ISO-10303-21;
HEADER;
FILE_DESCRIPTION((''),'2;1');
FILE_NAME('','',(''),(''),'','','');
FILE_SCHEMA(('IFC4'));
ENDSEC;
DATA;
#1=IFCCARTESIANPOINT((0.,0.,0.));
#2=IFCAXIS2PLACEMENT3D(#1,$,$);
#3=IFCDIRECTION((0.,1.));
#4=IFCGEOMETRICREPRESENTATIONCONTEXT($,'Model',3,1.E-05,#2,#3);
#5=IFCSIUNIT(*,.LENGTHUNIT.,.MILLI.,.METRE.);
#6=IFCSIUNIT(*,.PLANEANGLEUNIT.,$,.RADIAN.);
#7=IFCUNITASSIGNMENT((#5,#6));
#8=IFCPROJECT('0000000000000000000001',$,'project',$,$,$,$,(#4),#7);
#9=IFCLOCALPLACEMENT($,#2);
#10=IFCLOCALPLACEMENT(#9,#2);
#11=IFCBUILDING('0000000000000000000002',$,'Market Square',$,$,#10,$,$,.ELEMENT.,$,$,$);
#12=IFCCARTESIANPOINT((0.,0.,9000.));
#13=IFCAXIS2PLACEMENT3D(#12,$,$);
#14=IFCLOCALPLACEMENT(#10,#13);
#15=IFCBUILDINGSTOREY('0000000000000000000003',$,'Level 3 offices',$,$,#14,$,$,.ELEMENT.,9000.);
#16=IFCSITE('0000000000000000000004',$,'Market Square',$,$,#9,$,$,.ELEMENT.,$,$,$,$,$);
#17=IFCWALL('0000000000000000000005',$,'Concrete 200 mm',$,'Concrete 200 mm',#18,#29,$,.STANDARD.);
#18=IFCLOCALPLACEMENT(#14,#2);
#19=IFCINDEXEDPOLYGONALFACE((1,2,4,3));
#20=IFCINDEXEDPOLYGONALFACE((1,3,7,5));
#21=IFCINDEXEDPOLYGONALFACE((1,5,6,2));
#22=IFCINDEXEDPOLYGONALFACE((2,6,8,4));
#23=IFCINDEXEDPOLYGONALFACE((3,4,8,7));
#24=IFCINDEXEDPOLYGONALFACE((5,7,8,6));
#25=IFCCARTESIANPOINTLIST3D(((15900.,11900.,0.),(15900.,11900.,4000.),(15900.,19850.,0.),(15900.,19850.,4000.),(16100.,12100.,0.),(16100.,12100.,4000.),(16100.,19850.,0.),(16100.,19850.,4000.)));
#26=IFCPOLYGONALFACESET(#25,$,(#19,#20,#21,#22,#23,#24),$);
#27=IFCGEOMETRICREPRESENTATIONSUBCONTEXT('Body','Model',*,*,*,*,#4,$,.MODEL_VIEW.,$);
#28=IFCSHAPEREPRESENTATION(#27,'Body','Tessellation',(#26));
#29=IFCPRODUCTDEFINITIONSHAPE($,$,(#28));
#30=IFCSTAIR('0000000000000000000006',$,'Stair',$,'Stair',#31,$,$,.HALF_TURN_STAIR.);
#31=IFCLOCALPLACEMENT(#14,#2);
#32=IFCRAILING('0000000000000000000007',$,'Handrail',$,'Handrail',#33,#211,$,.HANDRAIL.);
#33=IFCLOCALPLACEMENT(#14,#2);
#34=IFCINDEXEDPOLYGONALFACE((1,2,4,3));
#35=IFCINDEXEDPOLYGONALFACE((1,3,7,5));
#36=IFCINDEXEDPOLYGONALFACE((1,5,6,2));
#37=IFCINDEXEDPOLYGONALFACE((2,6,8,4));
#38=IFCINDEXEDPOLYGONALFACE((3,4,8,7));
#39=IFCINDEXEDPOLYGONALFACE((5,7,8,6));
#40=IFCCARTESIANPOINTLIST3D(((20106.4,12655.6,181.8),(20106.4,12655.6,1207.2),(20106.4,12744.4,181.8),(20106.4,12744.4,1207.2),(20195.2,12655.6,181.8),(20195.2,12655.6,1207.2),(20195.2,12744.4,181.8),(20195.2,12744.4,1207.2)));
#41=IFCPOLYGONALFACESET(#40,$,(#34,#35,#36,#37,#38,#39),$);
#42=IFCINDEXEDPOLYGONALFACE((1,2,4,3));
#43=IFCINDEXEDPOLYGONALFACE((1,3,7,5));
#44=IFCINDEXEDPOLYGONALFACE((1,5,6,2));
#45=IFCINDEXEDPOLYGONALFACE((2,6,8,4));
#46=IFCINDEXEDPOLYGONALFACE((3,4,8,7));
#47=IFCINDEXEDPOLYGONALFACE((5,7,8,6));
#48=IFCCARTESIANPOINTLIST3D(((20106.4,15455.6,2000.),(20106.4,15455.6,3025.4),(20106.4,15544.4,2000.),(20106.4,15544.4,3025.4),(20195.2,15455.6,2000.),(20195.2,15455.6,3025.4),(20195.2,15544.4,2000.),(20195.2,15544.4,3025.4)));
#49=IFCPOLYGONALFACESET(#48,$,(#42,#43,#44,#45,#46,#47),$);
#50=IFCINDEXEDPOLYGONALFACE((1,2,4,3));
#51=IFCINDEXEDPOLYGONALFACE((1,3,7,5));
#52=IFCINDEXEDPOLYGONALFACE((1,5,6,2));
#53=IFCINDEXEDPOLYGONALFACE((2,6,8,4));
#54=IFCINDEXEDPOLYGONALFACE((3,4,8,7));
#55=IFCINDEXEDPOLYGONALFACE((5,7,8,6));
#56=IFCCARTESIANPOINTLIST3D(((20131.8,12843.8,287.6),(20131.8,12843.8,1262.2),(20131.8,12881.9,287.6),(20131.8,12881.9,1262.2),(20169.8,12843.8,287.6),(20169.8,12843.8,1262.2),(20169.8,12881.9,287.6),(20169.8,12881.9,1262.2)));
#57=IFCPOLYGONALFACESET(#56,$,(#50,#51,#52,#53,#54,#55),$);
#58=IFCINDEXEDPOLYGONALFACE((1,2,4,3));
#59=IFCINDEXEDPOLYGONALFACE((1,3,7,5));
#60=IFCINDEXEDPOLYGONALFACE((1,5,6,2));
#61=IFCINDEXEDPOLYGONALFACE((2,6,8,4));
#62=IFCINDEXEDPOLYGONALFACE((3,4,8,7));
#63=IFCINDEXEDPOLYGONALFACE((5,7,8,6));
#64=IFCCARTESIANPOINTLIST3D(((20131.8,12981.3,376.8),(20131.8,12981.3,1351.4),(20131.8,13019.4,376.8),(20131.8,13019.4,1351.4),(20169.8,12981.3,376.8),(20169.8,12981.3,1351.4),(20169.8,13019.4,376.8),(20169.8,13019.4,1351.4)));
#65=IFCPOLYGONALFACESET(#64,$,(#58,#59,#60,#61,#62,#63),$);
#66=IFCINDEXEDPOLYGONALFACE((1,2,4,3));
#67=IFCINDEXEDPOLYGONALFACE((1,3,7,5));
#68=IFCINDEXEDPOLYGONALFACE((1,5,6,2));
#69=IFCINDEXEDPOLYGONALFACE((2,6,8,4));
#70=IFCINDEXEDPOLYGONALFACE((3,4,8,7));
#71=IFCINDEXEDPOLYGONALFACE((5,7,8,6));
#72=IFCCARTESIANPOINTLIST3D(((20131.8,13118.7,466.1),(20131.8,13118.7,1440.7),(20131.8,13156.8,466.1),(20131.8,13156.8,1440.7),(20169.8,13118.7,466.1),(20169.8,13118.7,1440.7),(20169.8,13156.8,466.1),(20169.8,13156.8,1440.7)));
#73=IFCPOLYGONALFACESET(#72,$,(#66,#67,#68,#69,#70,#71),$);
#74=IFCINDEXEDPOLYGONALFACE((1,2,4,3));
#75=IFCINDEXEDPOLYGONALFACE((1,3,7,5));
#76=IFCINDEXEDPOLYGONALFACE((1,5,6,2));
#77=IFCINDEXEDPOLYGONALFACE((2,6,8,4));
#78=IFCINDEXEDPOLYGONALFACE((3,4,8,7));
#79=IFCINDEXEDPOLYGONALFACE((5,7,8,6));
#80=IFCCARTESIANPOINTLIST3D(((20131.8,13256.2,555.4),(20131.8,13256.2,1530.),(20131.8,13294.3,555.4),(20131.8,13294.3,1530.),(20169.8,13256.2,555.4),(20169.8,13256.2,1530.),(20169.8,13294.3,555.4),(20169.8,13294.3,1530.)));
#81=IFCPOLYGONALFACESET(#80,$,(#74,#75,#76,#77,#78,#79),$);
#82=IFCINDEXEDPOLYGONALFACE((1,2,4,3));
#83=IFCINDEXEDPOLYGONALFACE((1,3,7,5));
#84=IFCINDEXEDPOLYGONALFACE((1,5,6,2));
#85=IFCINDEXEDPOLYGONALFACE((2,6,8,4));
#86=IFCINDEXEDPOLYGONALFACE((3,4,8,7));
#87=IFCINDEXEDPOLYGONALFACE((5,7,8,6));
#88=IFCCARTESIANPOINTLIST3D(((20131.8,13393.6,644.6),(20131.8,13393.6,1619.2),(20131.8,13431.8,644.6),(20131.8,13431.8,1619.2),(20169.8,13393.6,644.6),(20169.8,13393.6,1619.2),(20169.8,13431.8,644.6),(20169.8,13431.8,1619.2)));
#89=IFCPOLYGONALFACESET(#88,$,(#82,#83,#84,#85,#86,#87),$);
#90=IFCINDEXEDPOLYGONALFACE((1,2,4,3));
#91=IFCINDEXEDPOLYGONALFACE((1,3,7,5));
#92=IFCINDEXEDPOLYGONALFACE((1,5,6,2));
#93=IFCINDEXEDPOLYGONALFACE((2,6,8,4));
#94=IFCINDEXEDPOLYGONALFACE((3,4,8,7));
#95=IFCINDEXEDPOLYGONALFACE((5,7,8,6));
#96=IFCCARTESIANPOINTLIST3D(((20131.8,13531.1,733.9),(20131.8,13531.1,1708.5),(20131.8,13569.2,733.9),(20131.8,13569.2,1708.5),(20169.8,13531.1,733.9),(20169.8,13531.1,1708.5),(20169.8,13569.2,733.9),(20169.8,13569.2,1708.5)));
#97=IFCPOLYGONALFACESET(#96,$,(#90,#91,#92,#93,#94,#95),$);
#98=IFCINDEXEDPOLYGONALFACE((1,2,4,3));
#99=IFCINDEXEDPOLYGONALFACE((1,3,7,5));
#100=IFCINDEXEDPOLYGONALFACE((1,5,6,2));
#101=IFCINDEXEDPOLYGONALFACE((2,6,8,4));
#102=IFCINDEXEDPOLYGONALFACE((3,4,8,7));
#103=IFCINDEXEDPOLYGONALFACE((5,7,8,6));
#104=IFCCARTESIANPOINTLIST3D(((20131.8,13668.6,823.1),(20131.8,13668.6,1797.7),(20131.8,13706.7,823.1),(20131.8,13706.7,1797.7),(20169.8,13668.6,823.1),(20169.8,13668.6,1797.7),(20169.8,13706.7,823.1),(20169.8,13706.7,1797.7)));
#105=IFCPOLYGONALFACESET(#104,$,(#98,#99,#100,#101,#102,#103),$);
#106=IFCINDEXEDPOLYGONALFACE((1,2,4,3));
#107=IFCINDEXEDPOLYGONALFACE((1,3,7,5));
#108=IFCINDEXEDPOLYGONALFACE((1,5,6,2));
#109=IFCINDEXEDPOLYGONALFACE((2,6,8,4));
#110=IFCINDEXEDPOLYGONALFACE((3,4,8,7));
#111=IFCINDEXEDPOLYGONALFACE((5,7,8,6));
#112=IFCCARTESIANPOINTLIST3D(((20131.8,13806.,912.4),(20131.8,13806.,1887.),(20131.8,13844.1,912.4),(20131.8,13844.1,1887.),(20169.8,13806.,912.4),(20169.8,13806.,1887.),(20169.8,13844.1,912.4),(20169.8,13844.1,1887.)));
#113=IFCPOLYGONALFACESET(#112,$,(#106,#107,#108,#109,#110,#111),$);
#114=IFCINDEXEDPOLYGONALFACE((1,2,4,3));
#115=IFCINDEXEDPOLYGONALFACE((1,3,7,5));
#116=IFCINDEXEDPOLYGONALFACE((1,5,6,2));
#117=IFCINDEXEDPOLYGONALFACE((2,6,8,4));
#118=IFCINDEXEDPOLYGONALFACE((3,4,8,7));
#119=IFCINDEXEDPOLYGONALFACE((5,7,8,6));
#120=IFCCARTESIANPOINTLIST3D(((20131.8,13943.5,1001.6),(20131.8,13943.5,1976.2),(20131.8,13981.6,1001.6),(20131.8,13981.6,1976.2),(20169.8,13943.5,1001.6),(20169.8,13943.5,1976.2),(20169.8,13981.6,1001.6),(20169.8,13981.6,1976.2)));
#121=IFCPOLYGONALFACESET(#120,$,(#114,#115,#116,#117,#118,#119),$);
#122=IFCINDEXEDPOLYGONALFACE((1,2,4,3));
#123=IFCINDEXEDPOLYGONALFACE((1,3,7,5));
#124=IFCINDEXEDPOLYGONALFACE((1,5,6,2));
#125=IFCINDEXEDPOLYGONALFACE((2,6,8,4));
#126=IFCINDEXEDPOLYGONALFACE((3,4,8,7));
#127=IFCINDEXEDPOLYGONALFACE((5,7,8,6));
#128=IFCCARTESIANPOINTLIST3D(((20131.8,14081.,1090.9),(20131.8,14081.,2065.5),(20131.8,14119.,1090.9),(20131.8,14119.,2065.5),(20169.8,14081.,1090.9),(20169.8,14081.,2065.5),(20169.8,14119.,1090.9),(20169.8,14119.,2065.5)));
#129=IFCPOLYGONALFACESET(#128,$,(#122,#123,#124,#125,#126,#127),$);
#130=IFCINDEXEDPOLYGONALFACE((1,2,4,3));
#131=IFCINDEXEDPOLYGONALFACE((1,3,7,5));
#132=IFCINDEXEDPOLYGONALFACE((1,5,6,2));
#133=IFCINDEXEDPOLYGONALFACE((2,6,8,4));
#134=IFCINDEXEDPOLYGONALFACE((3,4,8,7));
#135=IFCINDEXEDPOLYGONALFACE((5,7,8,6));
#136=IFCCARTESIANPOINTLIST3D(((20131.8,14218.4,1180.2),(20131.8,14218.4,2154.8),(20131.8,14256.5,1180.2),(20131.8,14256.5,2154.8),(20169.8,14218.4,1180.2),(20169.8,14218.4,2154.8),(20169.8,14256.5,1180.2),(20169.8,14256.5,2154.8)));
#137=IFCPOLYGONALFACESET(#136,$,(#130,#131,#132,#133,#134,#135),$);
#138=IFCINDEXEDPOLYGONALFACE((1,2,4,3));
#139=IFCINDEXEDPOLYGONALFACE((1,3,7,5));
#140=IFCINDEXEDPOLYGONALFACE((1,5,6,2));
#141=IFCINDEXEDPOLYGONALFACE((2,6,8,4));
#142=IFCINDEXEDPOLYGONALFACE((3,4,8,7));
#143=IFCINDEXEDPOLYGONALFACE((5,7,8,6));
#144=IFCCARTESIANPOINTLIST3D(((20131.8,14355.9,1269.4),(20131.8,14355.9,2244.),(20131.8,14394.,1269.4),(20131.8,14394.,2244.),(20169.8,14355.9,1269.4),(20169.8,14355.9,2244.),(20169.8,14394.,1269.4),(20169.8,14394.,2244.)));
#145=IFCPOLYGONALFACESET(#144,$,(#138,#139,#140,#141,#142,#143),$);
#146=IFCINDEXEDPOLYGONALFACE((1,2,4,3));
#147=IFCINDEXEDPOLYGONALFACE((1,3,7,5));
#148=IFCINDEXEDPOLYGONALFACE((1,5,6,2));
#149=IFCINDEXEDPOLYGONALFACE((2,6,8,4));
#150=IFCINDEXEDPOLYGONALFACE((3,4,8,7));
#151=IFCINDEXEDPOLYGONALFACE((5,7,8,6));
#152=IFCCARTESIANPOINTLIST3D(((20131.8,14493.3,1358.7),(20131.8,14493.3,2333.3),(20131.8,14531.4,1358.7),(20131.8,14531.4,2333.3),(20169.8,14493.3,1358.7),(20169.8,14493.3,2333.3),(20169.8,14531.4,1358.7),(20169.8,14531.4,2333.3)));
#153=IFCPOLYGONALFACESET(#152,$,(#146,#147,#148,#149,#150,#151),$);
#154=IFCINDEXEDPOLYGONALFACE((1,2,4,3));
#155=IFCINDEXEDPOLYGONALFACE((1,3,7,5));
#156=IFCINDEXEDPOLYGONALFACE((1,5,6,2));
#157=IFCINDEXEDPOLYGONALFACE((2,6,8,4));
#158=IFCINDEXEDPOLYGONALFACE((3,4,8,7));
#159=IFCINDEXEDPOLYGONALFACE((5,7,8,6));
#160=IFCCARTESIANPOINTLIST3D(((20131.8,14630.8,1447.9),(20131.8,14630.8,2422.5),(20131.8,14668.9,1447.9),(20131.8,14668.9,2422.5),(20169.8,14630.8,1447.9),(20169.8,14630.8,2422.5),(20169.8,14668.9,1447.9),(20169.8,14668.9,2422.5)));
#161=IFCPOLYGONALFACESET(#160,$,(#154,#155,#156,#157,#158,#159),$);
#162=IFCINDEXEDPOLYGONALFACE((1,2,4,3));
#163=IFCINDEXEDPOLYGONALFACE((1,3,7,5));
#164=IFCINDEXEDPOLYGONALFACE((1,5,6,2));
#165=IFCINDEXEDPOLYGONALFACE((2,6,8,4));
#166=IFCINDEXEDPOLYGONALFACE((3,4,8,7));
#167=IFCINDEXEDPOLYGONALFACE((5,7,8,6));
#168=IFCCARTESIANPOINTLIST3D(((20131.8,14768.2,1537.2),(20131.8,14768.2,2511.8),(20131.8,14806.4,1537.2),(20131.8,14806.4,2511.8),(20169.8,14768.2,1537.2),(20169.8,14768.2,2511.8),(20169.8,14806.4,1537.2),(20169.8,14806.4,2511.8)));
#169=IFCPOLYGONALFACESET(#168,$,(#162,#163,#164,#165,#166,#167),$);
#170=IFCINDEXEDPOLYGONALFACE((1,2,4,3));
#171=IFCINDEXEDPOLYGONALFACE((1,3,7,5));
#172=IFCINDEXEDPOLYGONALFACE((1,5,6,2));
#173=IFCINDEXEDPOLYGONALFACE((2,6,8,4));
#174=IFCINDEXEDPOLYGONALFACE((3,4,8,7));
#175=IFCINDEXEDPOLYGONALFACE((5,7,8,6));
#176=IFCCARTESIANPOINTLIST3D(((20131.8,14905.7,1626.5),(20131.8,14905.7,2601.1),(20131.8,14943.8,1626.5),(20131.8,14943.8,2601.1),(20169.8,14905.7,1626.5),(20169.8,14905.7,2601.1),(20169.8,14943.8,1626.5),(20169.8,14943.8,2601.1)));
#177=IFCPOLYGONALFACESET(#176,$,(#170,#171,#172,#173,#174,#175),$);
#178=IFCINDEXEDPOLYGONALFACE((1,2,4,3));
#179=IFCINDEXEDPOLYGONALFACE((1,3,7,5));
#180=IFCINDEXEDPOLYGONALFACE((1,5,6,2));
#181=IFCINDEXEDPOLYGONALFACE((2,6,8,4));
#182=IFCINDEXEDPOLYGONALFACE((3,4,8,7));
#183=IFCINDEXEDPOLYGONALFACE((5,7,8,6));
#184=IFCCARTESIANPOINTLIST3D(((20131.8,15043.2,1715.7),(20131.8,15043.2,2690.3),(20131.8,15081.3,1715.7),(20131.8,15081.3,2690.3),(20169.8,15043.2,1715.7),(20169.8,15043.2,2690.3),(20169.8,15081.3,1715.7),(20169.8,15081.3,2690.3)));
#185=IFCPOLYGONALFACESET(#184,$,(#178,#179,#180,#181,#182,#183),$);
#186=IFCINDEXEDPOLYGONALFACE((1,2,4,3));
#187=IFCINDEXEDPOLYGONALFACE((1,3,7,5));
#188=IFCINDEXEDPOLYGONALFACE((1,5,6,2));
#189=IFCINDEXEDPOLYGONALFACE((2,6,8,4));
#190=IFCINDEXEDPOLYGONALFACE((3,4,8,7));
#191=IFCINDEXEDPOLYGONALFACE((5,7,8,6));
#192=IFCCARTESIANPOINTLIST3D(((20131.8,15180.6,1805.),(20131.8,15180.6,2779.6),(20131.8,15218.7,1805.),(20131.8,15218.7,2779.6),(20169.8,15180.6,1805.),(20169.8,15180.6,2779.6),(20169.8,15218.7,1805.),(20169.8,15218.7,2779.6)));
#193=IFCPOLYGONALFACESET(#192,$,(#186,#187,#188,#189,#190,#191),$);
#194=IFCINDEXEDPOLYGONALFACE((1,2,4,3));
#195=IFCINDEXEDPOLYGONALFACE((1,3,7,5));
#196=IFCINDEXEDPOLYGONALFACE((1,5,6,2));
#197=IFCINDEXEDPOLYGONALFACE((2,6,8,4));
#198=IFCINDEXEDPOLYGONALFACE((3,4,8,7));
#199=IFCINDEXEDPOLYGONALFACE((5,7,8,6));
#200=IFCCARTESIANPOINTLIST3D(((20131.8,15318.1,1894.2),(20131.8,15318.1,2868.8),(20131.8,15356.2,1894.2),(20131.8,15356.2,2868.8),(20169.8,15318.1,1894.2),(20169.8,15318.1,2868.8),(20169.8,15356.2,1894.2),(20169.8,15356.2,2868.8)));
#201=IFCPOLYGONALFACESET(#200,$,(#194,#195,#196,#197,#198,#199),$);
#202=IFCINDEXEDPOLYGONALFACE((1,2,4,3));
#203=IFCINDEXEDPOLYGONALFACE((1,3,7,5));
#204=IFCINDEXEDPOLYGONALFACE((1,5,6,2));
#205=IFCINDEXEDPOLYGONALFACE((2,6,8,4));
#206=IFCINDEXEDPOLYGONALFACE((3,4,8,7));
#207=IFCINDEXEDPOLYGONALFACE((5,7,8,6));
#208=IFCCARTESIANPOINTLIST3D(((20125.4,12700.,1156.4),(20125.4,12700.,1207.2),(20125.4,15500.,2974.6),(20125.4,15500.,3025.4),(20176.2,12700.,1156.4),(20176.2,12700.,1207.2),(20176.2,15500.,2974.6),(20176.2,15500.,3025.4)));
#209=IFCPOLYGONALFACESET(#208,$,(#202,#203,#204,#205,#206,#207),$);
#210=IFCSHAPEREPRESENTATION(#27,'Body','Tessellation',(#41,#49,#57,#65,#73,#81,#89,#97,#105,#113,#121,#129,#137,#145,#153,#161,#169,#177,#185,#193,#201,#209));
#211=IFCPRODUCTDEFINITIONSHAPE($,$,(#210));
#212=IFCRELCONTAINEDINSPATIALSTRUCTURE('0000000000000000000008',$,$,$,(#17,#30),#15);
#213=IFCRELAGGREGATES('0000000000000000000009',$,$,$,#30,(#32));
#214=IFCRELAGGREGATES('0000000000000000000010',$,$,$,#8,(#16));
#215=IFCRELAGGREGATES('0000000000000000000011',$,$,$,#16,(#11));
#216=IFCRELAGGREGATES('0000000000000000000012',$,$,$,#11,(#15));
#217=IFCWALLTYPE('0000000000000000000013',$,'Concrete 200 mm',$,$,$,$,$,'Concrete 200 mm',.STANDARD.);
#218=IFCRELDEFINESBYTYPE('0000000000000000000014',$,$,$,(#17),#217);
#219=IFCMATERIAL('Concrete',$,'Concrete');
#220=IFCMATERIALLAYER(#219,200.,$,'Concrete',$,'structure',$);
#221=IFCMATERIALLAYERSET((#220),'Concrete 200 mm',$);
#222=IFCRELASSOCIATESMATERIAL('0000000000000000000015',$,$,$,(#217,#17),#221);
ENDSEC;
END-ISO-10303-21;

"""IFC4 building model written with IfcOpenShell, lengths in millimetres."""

from ifc_helpers import new_model, si_unit, direction, frame, origin, origin_with_axes, place, context, subcontext, project, spatial, polyline, outline, extrude, material, layer, layer_set, layer_usage, type_object, element, aggregate, save


model = new_model("IFC4")

# Units and contexts
model_context = context("Model", 3, precision=1e-05, world=origin(), true_north=direction((0.0, 1.0)))
body_context = subcontext(model_context, "Body", "Model", "MODEL_VIEW")
ifc_project = project(units=[si_unit("LENGTHUNIT", "METRE", prefix="MILLI"), si_unit("PLANEANGLEUNIT", "RADIAN")], contexts=[model_context])

# Site, building, storey
site_placement = place(None, origin())
site = spatial("IfcSite", under=ifc_project, at=site_placement, Name="Market Square", CompositionType="ELEMENT")
building_placement = place(site_placement, origin())
building = spatial("IfcBuilding", under=site, at=building_placement, Name="Market Square", CompositionType="ELEMENT")
storey_placement = place(building_placement, frame((0.0, 0.0, 9000.0)))
storey = spatial("IfcBuildingStorey", under=building, at=storey_placement, Name="Level 3 offices", CompositionType="ELEMENT", Elevation=9000.0)

# Wall
ifc_material = material(Name="Concrete", Category="Concrete")
ifc_layer = layer(ifc_material, 200.0, Name="Concrete", Category="structure")
ifc_layer_set = layer_set([ifc_layer], Name="Concrete 200 mm")
ifc_layer_usage = layer_usage(ifc_layer_set, "AXIS2", "NEGATIVE", 100.0)
wall_type = type_object("IfcWallType", Name="Concrete 200 mm", ElementType="Concrete 200 mm", PredefinedType="STANDARD", material=ifc_layer_set)
wall_placement = place(storey_placement, frame((16000.0, 12000.0, 0.0), z_axis=(0.0, 0.0, 1.0), x_axis=(0.0, 1.0, 0.0)))
element("IfcWall", 1, at=wall_placement, inside=storey, type_object=wall_type, material=ifc_layer_usage, Name="Concrete 200 mm", ObjectType="Concrete 200 mm", PredefinedType="STANDARD", context=body_context, shape_type="SweptSolid", body=[
    extrude(outline(polyline([(100.0, -100.0), (7850.0, -100.0), (7850.0, 100.0), (-100.0, 100.0), (100.0, -100.0)])), origin(), (0.0, 0.0, 1.0), 4000.0),
])

# Stair, railing
stair_placement = place(storey_placement, origin_with_axes())
stair = element("IfcStair", 2, at=stair_placement, inside=storey, Name="Stair", ObjectType="Stair", PredefinedType="HALF_TURN_STAIR")
railing_1_placement = place(storey_placement, origin_with_axes())
railing_1 = element("IfcRailing", 3, at=railing_1_placement, Name="Handrail", ObjectType="Handrail", PredefinedType="HANDRAIL", context=body_context, shape_type="SweptSolid", body=[
    extrude(outline(polyline([(-44.5, -44.5), (44.5, -44.5), (44.5, 44.5), (-44.5, 44.5), (-44.5, -44.5)])), frame((20150.8, 12700.0, 181.8), z_axis=(0.0, 0.0, 1.0), x_axis=(1.0, 0.0, 0.0)), (0.0, 0.0, 1.0), 1025.4),
    extrude(outline(polyline([(-44.5, -44.5), (44.5, -44.5), (44.5, 44.5), (-44.5, 44.5), (-44.5, -44.5)])), frame((20150.8, 15500.0, 2000.0), z_axis=(0.0, 0.0, 1.0), x_axis=(1.0, 0.0, 0.0)), (0.0, 0.0, 1.0), 1025.4),
    extrude(outline(polyline([(-19.1, -19.1), (19.1, -19.1), (19.1, 19.1), (-19.1, 19.1), (-19.1, -19.1)])), frame((20150.8, 12862.9, 287.6), z_axis=(0.0, 0.0, 1.0), x_axis=(1.0, 0.0, 0.0)), (0.0, 0.0, 1.0), 974.6),
    extrude(outline(polyline([(-19.1, -19.1), (19.1, -19.1), (19.1, 19.1), (-19.1, 19.1), (-19.1, -19.1)])), frame((20150.8, 13000.3, 376.8), z_axis=(0.0, 0.0, 1.0), x_axis=(1.0, 0.0, 0.0)), (0.0, 0.0, 1.0), 974.6),
    extrude(outline(polyline([(-19.1, -19.1), (19.1, -19.1), (19.1, 19.1), (-19.1, 19.1), (-19.1, -19.1)])), frame((20150.8, 13137.8, 466.1), z_axis=(0.0, 0.0, 1.0), x_axis=(1.0, 0.0, 0.0)), (0.0, 0.0, 1.0), 974.6),
    extrude(outline(polyline([(-19.1, -19.1), (19.1, -19.1), (19.1, 19.1), (-19.1, 19.1), (-19.1, -19.1)])), frame((20150.8, 13275.2, 555.4), z_axis=(0.0, 0.0, 1.0), x_axis=(1.0, 0.0, 0.0)), (0.0, 0.0, 1.0), 974.6),
    extrude(outline(polyline([(-19.1, -19.1), (19.1, -19.1), (19.1, 19.1), (-19.1, 19.1), (-19.1, -19.1)])), frame((20150.8, 13412.7, 644.6), z_axis=(0.0, 0.0, 1.0), x_axis=(1.0, 0.0, 0.0)), (0.0, 0.0, 1.0), 974.6),
    extrude(outline(polyline([(-19.1, -19.1), (19.1, -19.1), (19.1, 19.1), (-19.1, 19.1), (-19.1, -19.1)])), frame((20150.8, 13550.2, 733.9), z_axis=(0.0, 0.0, 1.0), x_axis=(1.0, 0.0, 0.0)), (0.0, 0.0, 1.0), 974.6),
    extrude(outline(polyline([(-19.1, -19.1), (19.1, -19.1), (19.1, 19.1), (-19.1, 19.1), (-19.1, -19.1)])), frame((20150.8, 13687.6, 823.1), z_axis=(0.0, 0.0, 1.0), x_axis=(1.0, 0.0, 0.0)), (0.0, 0.0, 1.0), 974.6),
    extrude(outline(polyline([(-19.1, -19.1), (19.1, -19.1), (19.1, 19.1), (-19.1, 19.1), (-19.1, -19.1)])), frame((20150.8, 13825.1, 912.4), z_axis=(0.0, 0.0, 1.0), x_axis=(1.0, 0.0, 0.0)), (0.0, 0.0, 1.0), 974.6),
    extrude(outline(polyline([(-19.1, -19.1), (19.1, -19.1), (19.1, 19.1), (-19.1, 19.1), (-19.1, -19.1)])), frame((20150.8, 13962.5, 1001.6), z_axis=(0.0, 0.0, 1.0), x_axis=(1.0, 0.0, 0.0)), (0.0, 0.0, 1.0), 974.6),
    extrude(outline(polyline([(-19.1, -19.1), (19.1, -19.1), (19.1, 19.1), (-19.1, 19.1), (-19.1, -19.1)])), frame((20150.8, 14100.0, 1090.9), z_axis=(0.0, 0.0, 1.0), x_axis=(1.0, 0.0, 0.0)), (0.0, 0.0, 1.0), 974.6),
    extrude(outline(polyline([(-19.1, -19.1), (19.1, -19.1), (19.1, 19.1), (-19.1, 19.1), (-19.1, -19.1)])), frame((20150.8, 14237.5, 1180.2), z_axis=(0.0, 0.0, 1.0), x_axis=(1.0, 0.0, 0.0)), (0.0, 0.0, 1.0), 974.6),
    extrude(outline(polyline([(-19.1, -19.1), (19.1, -19.1), (19.1, 19.1), (-19.1, 19.1), (-19.1, -19.1)])), frame((20150.8, 14374.9, 1269.4), z_axis=(0.0, 0.0, 1.0), x_axis=(1.0, 0.0, 0.0)), (0.0, 0.0, 1.0), 974.6),
    extrude(outline(polyline([(-19.1, -19.1), (19.1, -19.1), (19.1, 19.1), (-19.1, 19.1), (-19.1, -19.1)])), frame((20150.8, 14512.4, 1358.7), z_axis=(0.0, 0.0, 1.0), x_axis=(1.0, 0.0, 0.0)), (0.0, 0.0, 1.0), 974.6),
    extrude(outline(polyline([(-19.1, -19.1), (19.1, -19.1), (19.1, 19.1), (-19.1, 19.1), (-19.1, -19.1)])), frame((20150.8, 14649.8, 1447.9), z_axis=(0.0, 0.0, 1.0), x_axis=(1.0, 0.0, 0.0)), (0.0, 0.0, 1.0), 974.6),
    extrude(outline(polyline([(-19.1, -19.1), (19.1, -19.1), (19.1, 19.1), (-19.1, 19.1), (-19.1, -19.1)])), frame((20150.8, 14787.3, 1537.2), z_axis=(0.0, 0.0, 1.0), x_axis=(1.0, 0.0, 0.0)), (0.0, 0.0, 1.0), 974.6),
    extrude(outline(polyline([(-19.1, -19.1), (19.1, -19.1), (19.1, 19.1), (-19.1, 19.1), (-19.1, -19.1)])), frame((20150.8, 14924.8, 1626.5), z_axis=(0.0, 0.0, 1.0), x_axis=(1.0, 0.0, 0.0)), (0.0, 0.0, 1.0), 974.6),
    extrude(outline(polyline([(-19.1, -19.1), (19.1, -19.1), (19.1, 19.1), (-19.1, 19.1), (-19.1, -19.1)])), frame((20150.8, 15062.2, 1715.7), z_axis=(0.0, 0.0, 1.0), x_axis=(1.0, 0.0, 0.0)), (0.0, 0.0, 1.0), 974.6),
    extrude(outline(polyline([(-19.1, -19.1), (19.1, -19.1), (19.1, 19.1), (-19.1, 19.1), (-19.1, -19.1)])), frame((20150.8, 15199.7, 1805.0), z_axis=(0.0, 0.0, 1.0), x_axis=(1.0, 0.0, 0.0)), (0.0, 0.0, 1.0), 974.6),
    extrude(outline(polyline([(-19.1, -19.1), (19.1, -19.1), (19.1, 19.1), (-19.1, 19.1), (-19.1, -19.1)])), frame((20150.8, 15337.1, 1894.2), z_axis=(0.0, 0.0, 1.0), x_axis=(1.0, 0.0, 0.0)), (0.0, 0.0, 1.0), 974.6),
    extrude(outline(polyline([(0.0, 0.0), (50.8, 0.0), (50.8, 50.8), (0.0, 50.8), (0.0, 0.0)])), frame((20176.2, 12700.0, 1156.4), z_axis=(0.0, 1.0, 0.0), x_axis=(-1.0, 0.0, 0.0)), (0.0, 0.544605, 0.838692), 3338.5),
])
aggregate(stair, [railing_1])

save(model, "model.ifc")
